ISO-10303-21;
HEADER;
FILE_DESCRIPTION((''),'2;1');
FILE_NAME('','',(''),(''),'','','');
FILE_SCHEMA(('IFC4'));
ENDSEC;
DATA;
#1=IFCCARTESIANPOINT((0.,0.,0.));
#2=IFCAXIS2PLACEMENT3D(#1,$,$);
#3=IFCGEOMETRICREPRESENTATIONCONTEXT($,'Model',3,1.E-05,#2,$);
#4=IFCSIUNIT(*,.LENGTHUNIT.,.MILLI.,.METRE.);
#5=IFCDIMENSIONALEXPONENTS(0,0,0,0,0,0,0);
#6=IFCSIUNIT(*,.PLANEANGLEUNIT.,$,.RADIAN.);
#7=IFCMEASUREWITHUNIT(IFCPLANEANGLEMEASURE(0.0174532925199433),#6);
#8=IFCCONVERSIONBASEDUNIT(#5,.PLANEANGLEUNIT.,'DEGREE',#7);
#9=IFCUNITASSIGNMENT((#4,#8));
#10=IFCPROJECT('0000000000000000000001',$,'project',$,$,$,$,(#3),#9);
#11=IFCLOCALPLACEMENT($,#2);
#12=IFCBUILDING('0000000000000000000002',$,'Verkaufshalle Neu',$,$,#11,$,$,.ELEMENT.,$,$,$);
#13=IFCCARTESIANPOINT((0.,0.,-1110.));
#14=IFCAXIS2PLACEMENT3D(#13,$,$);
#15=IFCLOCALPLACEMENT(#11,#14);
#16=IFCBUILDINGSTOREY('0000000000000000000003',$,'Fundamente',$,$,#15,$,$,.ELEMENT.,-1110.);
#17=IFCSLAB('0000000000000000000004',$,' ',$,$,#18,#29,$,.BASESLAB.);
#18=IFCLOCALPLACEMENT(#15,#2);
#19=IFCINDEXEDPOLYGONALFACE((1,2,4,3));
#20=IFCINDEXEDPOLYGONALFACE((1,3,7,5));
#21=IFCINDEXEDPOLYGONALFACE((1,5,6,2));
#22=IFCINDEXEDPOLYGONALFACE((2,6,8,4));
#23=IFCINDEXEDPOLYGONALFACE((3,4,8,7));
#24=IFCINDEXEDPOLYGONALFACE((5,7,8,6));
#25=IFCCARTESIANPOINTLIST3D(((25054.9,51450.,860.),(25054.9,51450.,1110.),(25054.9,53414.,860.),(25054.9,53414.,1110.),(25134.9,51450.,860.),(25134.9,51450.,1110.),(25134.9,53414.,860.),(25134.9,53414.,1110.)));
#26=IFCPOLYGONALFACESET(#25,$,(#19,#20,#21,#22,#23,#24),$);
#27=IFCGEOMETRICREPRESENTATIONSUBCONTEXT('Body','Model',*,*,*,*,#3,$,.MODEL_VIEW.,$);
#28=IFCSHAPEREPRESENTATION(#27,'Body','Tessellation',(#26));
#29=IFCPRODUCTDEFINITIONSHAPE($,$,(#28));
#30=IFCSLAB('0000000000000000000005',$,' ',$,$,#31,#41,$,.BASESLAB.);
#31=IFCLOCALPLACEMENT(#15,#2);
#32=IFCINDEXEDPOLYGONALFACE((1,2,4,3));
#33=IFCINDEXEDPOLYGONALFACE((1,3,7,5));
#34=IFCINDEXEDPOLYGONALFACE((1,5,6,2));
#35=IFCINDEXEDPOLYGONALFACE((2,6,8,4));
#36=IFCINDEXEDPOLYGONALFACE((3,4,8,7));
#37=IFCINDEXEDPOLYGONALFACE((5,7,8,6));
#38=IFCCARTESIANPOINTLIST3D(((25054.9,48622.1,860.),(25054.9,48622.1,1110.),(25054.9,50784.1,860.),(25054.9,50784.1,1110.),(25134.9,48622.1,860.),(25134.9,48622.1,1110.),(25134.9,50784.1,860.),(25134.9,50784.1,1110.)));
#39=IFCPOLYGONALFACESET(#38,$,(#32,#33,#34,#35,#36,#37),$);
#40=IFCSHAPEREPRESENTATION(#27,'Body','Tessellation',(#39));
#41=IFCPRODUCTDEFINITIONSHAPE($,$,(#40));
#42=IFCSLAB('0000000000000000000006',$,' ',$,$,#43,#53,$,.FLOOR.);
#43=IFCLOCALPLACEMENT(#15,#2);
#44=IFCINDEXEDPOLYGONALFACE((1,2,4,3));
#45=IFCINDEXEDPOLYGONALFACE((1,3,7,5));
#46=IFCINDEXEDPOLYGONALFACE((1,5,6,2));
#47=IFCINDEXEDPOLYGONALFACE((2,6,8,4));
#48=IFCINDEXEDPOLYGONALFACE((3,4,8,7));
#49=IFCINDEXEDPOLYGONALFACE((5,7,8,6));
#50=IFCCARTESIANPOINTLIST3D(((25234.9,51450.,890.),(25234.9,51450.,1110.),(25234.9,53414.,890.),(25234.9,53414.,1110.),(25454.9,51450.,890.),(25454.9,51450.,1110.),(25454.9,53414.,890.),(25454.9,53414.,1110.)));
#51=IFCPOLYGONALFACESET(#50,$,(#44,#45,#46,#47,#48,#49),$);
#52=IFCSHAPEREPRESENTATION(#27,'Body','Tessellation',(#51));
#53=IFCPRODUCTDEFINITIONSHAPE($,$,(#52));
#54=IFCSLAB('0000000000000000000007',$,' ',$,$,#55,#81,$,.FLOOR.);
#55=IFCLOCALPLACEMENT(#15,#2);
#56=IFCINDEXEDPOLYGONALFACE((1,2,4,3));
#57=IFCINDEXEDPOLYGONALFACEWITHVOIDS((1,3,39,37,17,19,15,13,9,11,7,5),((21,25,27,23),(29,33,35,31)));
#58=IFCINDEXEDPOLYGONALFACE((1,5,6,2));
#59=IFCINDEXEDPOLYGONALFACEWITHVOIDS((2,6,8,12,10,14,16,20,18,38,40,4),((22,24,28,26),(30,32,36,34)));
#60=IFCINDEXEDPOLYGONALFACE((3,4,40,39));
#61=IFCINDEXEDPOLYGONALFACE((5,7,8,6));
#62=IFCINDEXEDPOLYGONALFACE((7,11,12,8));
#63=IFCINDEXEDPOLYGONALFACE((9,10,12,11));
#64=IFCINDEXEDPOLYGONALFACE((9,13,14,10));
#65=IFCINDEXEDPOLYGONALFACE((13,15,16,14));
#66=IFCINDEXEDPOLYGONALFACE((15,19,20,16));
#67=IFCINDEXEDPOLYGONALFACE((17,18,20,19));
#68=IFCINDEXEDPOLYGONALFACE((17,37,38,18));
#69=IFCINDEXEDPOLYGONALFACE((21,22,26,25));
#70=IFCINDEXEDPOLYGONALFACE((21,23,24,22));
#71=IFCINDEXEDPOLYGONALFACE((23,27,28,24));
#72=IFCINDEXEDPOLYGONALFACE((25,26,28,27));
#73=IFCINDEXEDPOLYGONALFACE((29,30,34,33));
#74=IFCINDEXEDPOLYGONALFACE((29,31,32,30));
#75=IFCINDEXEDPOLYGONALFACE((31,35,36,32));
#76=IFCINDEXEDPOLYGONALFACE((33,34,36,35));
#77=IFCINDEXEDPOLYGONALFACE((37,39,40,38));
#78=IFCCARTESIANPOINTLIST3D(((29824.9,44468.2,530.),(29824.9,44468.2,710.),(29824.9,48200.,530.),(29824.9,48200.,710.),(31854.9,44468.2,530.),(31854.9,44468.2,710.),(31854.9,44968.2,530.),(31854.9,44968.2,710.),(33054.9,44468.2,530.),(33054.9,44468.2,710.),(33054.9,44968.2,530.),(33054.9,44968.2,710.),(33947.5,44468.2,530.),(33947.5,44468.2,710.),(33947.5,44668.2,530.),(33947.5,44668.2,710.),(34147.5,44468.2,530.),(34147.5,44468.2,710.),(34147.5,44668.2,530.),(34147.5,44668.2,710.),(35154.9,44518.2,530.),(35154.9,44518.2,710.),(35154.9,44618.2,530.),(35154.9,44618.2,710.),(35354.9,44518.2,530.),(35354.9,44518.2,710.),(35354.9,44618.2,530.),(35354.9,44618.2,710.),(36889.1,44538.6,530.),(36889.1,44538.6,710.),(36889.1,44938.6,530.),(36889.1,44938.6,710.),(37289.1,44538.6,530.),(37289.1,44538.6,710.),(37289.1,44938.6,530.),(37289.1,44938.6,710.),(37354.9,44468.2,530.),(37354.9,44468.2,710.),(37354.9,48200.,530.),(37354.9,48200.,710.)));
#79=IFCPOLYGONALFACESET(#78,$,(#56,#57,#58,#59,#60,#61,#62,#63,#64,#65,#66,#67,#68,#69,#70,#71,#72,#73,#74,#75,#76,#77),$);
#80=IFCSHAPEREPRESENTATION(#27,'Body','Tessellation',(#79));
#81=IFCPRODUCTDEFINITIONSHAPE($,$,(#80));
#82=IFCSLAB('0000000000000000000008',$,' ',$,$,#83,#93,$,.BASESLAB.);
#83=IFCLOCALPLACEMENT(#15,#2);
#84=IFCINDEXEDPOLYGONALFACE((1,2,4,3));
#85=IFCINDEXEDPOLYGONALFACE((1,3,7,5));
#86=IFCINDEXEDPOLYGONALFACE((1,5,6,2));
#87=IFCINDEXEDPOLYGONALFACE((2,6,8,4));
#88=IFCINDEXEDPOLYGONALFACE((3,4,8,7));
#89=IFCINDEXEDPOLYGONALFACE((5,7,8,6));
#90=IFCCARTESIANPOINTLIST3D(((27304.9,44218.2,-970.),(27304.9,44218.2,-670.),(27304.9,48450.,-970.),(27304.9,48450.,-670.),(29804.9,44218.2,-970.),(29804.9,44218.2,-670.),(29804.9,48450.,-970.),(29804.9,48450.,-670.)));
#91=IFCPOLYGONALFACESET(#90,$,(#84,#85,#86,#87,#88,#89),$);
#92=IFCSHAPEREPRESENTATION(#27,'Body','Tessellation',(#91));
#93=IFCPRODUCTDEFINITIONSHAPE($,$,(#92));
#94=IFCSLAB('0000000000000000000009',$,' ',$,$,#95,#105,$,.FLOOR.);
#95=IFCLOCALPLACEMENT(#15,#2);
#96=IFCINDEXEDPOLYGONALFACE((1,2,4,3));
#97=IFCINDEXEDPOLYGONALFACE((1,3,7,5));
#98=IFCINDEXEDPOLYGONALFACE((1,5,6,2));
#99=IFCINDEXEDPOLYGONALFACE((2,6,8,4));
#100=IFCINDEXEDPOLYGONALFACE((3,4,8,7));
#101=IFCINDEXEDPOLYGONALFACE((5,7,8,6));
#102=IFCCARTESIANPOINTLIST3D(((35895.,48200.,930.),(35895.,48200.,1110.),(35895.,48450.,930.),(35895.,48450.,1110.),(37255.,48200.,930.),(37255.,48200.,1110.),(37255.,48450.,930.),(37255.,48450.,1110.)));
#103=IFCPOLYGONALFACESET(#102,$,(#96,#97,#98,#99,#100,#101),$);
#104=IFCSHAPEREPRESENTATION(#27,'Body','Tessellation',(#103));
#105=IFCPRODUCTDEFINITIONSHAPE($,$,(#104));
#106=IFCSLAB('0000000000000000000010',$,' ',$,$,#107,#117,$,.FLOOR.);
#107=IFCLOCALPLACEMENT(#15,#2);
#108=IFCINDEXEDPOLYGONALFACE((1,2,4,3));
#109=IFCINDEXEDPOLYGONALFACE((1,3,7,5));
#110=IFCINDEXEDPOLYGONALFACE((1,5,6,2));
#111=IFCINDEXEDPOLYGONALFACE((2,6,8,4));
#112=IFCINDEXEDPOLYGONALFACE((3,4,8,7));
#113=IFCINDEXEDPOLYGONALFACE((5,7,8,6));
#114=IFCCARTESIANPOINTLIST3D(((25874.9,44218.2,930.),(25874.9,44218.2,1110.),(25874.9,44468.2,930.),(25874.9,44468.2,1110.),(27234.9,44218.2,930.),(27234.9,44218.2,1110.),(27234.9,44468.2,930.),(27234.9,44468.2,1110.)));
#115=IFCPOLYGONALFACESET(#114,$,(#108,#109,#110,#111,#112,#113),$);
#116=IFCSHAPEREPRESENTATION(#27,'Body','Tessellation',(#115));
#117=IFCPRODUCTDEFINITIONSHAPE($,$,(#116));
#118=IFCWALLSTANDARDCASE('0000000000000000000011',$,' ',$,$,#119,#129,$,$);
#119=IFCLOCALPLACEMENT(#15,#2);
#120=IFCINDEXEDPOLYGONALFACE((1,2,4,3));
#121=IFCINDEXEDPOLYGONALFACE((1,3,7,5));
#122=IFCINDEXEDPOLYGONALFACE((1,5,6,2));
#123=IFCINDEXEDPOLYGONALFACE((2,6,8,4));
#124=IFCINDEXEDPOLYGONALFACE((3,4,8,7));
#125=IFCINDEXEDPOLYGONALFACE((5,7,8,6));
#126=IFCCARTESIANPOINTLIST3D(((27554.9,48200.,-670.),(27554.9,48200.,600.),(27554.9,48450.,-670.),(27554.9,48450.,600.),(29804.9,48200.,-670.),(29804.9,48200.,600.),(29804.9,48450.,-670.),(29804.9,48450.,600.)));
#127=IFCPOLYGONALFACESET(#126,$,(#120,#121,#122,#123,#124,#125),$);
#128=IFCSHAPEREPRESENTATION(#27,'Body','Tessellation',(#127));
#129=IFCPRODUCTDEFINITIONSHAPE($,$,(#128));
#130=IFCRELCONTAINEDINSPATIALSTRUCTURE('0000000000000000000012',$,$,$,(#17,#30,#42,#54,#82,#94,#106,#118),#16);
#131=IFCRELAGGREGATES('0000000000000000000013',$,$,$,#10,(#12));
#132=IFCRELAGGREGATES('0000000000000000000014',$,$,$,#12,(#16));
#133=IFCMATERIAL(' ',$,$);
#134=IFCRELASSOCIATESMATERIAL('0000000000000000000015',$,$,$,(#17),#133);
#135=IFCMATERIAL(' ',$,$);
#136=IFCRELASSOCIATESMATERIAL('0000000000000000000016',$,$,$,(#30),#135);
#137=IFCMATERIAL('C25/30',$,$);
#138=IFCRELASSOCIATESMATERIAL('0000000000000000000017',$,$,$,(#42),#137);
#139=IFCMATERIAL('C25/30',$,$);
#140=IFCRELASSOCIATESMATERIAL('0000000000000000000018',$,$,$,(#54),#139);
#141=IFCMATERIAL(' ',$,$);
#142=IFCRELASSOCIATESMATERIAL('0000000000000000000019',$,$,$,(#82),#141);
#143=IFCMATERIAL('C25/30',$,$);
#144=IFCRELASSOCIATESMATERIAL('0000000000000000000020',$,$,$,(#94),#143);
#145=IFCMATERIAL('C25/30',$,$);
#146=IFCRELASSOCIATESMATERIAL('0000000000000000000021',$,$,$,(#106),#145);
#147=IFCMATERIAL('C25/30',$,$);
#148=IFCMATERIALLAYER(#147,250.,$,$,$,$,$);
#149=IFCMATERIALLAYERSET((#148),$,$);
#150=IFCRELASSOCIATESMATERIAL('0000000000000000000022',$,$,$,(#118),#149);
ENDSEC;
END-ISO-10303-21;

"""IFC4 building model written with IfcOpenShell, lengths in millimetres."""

from ifc_helpers import new_model, entity, si_unit, converted_unit, frame, frame_2d, origin, origin_with_axes, place, context, subcontext, project, spatial, rectangle, extrude, material, layer, layer_set, layer_usage, element, save


model = new_model("IFC4")

# Units and contexts
model_context = context("Model", 3, precision=1e-05, world=origin())
body_context = subcontext(model_context, "Body", "Model", "MODEL_VIEW")
ifc_project = project(units=[si_unit("LENGTHUNIT", "METRE", prefix="MILLI"), converted_unit("PLANEANGLEUNIT", "DEGREE", entity("IfcPlaneAngleMeasure", 0.0174532925199433), si_unit("PLANEANGLEUNIT", "RADIAN"), dimensions=[0, 0, 0, 0, 0, 0, 0])], contexts=[model_context])

# Building, storey
building_placement = place(None, origin())
building = spatial("IfcBuilding", under=ifc_project, at=building_placement, Name="Verkaufshalle Neu", CompositionType="ELEMENT")
storey_placement = place(building_placement, frame((0.0, 0.0, -1110.0)))
storey = spatial("IfcBuildingStorey", under=building, at=storey_placement, Name="Fundamente", CompositionType="ELEMENT", Elevation=-1110.0)

# Slabs
ifc_material_1 = material(Name=" ")
slab_1_placement = place(storey_placement, frame((25054.9, 51450.0, 860.0)))
element("IfcSlab", 1, at=slab_1_placement, inside=storey, material=ifc_material_1, Name=" ", PredefinedType="BASESLAB", context=body_context, shape_type="SweptSolid", body=[
    extrude(rectangle(XDim=1964.0, YDim=80.0, at=frame_2d((40.0, -982.0), x_axis=(0.0, -1.0))), frame((0.0, 1964.0, 0.0), z_axis=(0.0, 0.0, 1.0), x_axis=(1.0, 0.0, 0.0)), (0.0, 0.0, 1.0), 250.0),
])
ifc_material_2 = material(Name=" ")
slab_2_placement = place(storey_placement, frame((25054.9, 48622.1, 860.0)))
element("IfcSlab", 2, at=slab_2_placement, inside=storey, material=ifc_material_2, Name=" ", PredefinedType="BASESLAB", context=body_context, shape_type="SweptSolid", body=[
    extrude(rectangle(XDim=2162.0, YDim=80.0, at=frame_2d((40.0, -1081.0), x_axis=(0.0, -1.0))), frame((0.0, 2162.0, 0.0), z_axis=(0.0, 0.0, 1.0), x_axis=(1.0, 0.0, 0.0)), (0.0, 0.0, 1.0), 250.0),
])
ifc_material_3 = material(Name="C25/30")
slab_3_placement = place(storey_placement, frame((25234.9, 51450.0, 890.0)))
element("IfcSlab", 3, at=slab_3_placement, inside=storey, material=ifc_material_3, Name=" ", PredefinedType="FLOOR", context=body_context, shape_type="SweptSolid", body=[
    extrude(rectangle(XDim=1964.0, YDim=220.0, at=frame_2d((110.0, -982.0), x_axis=(0.0, -1.0))), frame((0.0, 1964.0, 0.0), z_axis=(0.0, 0.0, 1.0), x_axis=(1.0, 0.0, 0.0)), (0.0, 0.0, 1.0), 220.0),
])

# Slab, openings
ifc_material_4 = material(Name="C25/30")
slab_4_placement = place(storey_placement, frame((29824.9, 44468.2, 530.0)))
slab_4 = element("IfcSlab", 4, at=slab_4_placement, inside=storey, material=ifc_material_4, Name=" ", PredefinedType="FLOOR", context=body_context, shape_type="SweptSolid", body=[
    extrude(rectangle(XDim=3731.8, YDim=7530.0, at=frame_2d((3765.0, -1865.9), x_axis=(0.0, -1.0))), frame((0.0, 3731.8, 0.0), z_axis=(0.0, 0.0, 1.0), x_axis=(1.0, 0.0, 0.0)), (0.0, 0.0, 1.0), 180.0),
])
opening_1_placement = place(slab_4_placement, frame((11325.1, 100.0, 0.0)))
element("IfcOpeningStandardCase", 5, at=opening_1_placement, cuts=slab_4, PredefinedType="OPENING", context=body_context, shape_type="SweptSolid", body=[
    extrude(rectangle(XDim=100.0, YDim=100.0, at=frame_2d((0.0, 0.0), x_axis=(-1.0, 0.0))), frame((50.0, 50.0, 0.0), z_axis=(0.0, 0.0, 1.0), x_axis=(1.0, 0.0, 0.0)), (0.0, 0.0, 1.0), 180.0),
])
opening_2_placement = place(slab_4_placement, frame((11525.1, 3481.8, 0.0)))
element("IfcOpeningStandardCase", 6, at=opening_2_placement, cuts=slab_4, PredefinedType="OPENING", context=body_context, shape_type="SweptSolid", body=[
    extrude(rectangle(XDim=250.0, YDim=250.0, at=frame_2d((0.0, 0.0), x_axis=(-1.0, 0.0))), frame((125.0, 125.0, 0.0), z_axis=(0.0, 0.0, 1.0), x_axis=(1.0, 0.0, 0.0)), (0.0, 0.0, 1.0), 180.0),
])
opening_3_placement = place(slab_4_placement, frame((2030.0, 0.0, 0.0)))
element("IfcOpeningStandardCase", 7, at=opening_3_placement, cuts=slab_4, PredefinedType="OPENING", context=body_context, shape_type="SweptSolid", body=[
    extrude(rectangle(XDim=1200.0, YDim=500.0, at=frame_2d((0.0, 0.0), x_axis=(-1.0, 0.0))), frame((600.0, 250.0, 0.0), z_axis=(0.0, 0.0, 1.0), x_axis=(1.0, 0.0, 0.0)), (0.0, 0.0, 1.0), 180.0),
])
opening_4_placement = place(slab_4_placement, frame((4122.6, 0.0, 0.0)))
element("IfcOpeningStandardCase", 8, at=opening_4_placement, cuts=slab_4, PredefinedType="OPENING", context=body_context, shape_type="SweptSolid", body=[
    extrude(rectangle(XDim=200.0, YDim=200.0, at=frame_2d((0.0, 0.0), x_axis=(-1.0, 0.0))), frame((100.0, 100.0, 0.0), z_axis=(0.0, 0.0, 1.0), x_axis=(1.0, 0.0, 0.0)), (0.0, 0.0, 1.0), 180.0),
])
opening_5_placement = place(slab_4_placement, frame((5330.0, 50.0, 0.0)))
element("IfcOpeningStandardCase", 9, at=opening_5_placement, cuts=slab_4, PredefinedType="OPENING", context=body_context, shape_type="SweptSolid", body=[
    extrude(rectangle(XDim=200.0, YDim=100.0, at=frame_2d((0.0, 0.0), x_axis=(-1.0, 0.0))), frame((100.0, 50.0, 0.0), z_axis=(0.0, 0.0, 1.0), x_axis=(1.0, 0.0, 0.0)), (0.0, 0.0, 1.0), 180.0),
])
opening_6_placement = place(slab_4_placement, frame((7064.2, 70.4, 0.0)))
element("IfcOpeningStandardCase", 10, at=opening_6_placement, cuts=slab_4, PredefinedType="OPENING", context=body_context, shape_type="SweptSolid", body=[
    extrude(rectangle(XDim=400.0, YDim=400.0, at=frame_2d((0.0, 0.0), x_axis=(-1.0, 0.0))), frame((200.0, 200.0, 0.0), z_axis=(0.0, 0.0, 1.0), x_axis=(1.0, 0.0, 0.0)), (0.0, 0.0, 1.0), 180.0),
])

# Slabs
ifc_material_5 = material(Name=" ")
slab_5_placement = place(storey_placement, frame((27304.9, 44218.2, -970.0)))
element("IfcSlab", 11, at=slab_5_placement, inside=storey, material=ifc_material_5, Name=" ", PredefinedType="BASESLAB", context=body_context, shape_type="SweptSolid", body=[
    extrude(rectangle(XDim=4231.8, YDim=2500.0, at=frame_2d((1250.0, -2115.9), x_axis=(0.0, -1.0))), frame((0.0, 4231.8, 0.0), z_axis=(0.0, 0.0, 1.0), x_axis=(1.0, 0.0, 0.0)), (0.0, 0.0, 1.0), 300.0),
])
ifc_material_6 = material(Name="C25/30")
slab_6_placement = place(storey_placement, frame((35895.0, 48200.0, 930.0)))
element("IfcSlab", 12, at=slab_6_placement, inside=storey, material=ifc_material_6, Name=" ", PredefinedType="FLOOR", context=body_context, shape_type="SweptSolid", body=[
    extrude(rectangle(XDim=250.0, YDim=1360.0, at=frame_2d((680.0, -125.0), x_axis=(0.0, -1.0))), frame((0.0, 250.0, 0.0), z_axis=(0.0, 0.0, 1.0), x_axis=(1.0, 0.0, 0.0)), (0.0, 0.0, 1.0), 180.0),
])
ifc_material_7 = material(Name="C25/30")
slab_7_placement = place(storey_placement, frame((25874.9, 44218.2, 930.0)))
element("IfcSlab", 13, at=slab_7_placement, inside=storey, material=ifc_material_7, Name=" ", PredefinedType="FLOOR", context=body_context, shape_type="SweptSolid", body=[
    extrude(rectangle(XDim=250.0, YDim=1360.0, at=frame_2d((680.0, -125.0), x_axis=(0.0, -1.0))), frame((0.0, 250.0, 0.0), z_axis=(0.0, 0.0, 1.0), x_axis=(1.0, 0.0, 0.0)), (0.0, 0.0, 1.0), 180.0),
])

# Wall
ifc_material_8 = material(Name="C25/30")
ifc_layer_1 = layer(ifc_material_8, 250.0)
ifc_layer_set_1 = layer_set([ifc_layer_1])
ifc_layer_usage_1 = layer_usage(ifc_layer_set_1, "AXIS2", "POSITIVE", 0.0)
wall_1_placement = place(storey_placement, frame((29804.9, 48450.0, -670.0), z_axis=(0.0, 0.0, 1.0), x_axis=(-1.0, 0.0, 0.0)))
element("IfcWallStandardCase", 14, at=wall_1_placement, inside=storey, material=ifc_layer_usage_1, Name=" ", context=body_context, shape_type="SweptSolid", body=[
    extrude(rectangle(XDim=2250.0, YDim=250.0, at=frame_2d((1125.0, 125.0), x_axis=(1.0, 0.0))), origin_with_axes(), (0.0, 0.0, 1.0), 1270.0),
])

save(model, "model.ifc")
